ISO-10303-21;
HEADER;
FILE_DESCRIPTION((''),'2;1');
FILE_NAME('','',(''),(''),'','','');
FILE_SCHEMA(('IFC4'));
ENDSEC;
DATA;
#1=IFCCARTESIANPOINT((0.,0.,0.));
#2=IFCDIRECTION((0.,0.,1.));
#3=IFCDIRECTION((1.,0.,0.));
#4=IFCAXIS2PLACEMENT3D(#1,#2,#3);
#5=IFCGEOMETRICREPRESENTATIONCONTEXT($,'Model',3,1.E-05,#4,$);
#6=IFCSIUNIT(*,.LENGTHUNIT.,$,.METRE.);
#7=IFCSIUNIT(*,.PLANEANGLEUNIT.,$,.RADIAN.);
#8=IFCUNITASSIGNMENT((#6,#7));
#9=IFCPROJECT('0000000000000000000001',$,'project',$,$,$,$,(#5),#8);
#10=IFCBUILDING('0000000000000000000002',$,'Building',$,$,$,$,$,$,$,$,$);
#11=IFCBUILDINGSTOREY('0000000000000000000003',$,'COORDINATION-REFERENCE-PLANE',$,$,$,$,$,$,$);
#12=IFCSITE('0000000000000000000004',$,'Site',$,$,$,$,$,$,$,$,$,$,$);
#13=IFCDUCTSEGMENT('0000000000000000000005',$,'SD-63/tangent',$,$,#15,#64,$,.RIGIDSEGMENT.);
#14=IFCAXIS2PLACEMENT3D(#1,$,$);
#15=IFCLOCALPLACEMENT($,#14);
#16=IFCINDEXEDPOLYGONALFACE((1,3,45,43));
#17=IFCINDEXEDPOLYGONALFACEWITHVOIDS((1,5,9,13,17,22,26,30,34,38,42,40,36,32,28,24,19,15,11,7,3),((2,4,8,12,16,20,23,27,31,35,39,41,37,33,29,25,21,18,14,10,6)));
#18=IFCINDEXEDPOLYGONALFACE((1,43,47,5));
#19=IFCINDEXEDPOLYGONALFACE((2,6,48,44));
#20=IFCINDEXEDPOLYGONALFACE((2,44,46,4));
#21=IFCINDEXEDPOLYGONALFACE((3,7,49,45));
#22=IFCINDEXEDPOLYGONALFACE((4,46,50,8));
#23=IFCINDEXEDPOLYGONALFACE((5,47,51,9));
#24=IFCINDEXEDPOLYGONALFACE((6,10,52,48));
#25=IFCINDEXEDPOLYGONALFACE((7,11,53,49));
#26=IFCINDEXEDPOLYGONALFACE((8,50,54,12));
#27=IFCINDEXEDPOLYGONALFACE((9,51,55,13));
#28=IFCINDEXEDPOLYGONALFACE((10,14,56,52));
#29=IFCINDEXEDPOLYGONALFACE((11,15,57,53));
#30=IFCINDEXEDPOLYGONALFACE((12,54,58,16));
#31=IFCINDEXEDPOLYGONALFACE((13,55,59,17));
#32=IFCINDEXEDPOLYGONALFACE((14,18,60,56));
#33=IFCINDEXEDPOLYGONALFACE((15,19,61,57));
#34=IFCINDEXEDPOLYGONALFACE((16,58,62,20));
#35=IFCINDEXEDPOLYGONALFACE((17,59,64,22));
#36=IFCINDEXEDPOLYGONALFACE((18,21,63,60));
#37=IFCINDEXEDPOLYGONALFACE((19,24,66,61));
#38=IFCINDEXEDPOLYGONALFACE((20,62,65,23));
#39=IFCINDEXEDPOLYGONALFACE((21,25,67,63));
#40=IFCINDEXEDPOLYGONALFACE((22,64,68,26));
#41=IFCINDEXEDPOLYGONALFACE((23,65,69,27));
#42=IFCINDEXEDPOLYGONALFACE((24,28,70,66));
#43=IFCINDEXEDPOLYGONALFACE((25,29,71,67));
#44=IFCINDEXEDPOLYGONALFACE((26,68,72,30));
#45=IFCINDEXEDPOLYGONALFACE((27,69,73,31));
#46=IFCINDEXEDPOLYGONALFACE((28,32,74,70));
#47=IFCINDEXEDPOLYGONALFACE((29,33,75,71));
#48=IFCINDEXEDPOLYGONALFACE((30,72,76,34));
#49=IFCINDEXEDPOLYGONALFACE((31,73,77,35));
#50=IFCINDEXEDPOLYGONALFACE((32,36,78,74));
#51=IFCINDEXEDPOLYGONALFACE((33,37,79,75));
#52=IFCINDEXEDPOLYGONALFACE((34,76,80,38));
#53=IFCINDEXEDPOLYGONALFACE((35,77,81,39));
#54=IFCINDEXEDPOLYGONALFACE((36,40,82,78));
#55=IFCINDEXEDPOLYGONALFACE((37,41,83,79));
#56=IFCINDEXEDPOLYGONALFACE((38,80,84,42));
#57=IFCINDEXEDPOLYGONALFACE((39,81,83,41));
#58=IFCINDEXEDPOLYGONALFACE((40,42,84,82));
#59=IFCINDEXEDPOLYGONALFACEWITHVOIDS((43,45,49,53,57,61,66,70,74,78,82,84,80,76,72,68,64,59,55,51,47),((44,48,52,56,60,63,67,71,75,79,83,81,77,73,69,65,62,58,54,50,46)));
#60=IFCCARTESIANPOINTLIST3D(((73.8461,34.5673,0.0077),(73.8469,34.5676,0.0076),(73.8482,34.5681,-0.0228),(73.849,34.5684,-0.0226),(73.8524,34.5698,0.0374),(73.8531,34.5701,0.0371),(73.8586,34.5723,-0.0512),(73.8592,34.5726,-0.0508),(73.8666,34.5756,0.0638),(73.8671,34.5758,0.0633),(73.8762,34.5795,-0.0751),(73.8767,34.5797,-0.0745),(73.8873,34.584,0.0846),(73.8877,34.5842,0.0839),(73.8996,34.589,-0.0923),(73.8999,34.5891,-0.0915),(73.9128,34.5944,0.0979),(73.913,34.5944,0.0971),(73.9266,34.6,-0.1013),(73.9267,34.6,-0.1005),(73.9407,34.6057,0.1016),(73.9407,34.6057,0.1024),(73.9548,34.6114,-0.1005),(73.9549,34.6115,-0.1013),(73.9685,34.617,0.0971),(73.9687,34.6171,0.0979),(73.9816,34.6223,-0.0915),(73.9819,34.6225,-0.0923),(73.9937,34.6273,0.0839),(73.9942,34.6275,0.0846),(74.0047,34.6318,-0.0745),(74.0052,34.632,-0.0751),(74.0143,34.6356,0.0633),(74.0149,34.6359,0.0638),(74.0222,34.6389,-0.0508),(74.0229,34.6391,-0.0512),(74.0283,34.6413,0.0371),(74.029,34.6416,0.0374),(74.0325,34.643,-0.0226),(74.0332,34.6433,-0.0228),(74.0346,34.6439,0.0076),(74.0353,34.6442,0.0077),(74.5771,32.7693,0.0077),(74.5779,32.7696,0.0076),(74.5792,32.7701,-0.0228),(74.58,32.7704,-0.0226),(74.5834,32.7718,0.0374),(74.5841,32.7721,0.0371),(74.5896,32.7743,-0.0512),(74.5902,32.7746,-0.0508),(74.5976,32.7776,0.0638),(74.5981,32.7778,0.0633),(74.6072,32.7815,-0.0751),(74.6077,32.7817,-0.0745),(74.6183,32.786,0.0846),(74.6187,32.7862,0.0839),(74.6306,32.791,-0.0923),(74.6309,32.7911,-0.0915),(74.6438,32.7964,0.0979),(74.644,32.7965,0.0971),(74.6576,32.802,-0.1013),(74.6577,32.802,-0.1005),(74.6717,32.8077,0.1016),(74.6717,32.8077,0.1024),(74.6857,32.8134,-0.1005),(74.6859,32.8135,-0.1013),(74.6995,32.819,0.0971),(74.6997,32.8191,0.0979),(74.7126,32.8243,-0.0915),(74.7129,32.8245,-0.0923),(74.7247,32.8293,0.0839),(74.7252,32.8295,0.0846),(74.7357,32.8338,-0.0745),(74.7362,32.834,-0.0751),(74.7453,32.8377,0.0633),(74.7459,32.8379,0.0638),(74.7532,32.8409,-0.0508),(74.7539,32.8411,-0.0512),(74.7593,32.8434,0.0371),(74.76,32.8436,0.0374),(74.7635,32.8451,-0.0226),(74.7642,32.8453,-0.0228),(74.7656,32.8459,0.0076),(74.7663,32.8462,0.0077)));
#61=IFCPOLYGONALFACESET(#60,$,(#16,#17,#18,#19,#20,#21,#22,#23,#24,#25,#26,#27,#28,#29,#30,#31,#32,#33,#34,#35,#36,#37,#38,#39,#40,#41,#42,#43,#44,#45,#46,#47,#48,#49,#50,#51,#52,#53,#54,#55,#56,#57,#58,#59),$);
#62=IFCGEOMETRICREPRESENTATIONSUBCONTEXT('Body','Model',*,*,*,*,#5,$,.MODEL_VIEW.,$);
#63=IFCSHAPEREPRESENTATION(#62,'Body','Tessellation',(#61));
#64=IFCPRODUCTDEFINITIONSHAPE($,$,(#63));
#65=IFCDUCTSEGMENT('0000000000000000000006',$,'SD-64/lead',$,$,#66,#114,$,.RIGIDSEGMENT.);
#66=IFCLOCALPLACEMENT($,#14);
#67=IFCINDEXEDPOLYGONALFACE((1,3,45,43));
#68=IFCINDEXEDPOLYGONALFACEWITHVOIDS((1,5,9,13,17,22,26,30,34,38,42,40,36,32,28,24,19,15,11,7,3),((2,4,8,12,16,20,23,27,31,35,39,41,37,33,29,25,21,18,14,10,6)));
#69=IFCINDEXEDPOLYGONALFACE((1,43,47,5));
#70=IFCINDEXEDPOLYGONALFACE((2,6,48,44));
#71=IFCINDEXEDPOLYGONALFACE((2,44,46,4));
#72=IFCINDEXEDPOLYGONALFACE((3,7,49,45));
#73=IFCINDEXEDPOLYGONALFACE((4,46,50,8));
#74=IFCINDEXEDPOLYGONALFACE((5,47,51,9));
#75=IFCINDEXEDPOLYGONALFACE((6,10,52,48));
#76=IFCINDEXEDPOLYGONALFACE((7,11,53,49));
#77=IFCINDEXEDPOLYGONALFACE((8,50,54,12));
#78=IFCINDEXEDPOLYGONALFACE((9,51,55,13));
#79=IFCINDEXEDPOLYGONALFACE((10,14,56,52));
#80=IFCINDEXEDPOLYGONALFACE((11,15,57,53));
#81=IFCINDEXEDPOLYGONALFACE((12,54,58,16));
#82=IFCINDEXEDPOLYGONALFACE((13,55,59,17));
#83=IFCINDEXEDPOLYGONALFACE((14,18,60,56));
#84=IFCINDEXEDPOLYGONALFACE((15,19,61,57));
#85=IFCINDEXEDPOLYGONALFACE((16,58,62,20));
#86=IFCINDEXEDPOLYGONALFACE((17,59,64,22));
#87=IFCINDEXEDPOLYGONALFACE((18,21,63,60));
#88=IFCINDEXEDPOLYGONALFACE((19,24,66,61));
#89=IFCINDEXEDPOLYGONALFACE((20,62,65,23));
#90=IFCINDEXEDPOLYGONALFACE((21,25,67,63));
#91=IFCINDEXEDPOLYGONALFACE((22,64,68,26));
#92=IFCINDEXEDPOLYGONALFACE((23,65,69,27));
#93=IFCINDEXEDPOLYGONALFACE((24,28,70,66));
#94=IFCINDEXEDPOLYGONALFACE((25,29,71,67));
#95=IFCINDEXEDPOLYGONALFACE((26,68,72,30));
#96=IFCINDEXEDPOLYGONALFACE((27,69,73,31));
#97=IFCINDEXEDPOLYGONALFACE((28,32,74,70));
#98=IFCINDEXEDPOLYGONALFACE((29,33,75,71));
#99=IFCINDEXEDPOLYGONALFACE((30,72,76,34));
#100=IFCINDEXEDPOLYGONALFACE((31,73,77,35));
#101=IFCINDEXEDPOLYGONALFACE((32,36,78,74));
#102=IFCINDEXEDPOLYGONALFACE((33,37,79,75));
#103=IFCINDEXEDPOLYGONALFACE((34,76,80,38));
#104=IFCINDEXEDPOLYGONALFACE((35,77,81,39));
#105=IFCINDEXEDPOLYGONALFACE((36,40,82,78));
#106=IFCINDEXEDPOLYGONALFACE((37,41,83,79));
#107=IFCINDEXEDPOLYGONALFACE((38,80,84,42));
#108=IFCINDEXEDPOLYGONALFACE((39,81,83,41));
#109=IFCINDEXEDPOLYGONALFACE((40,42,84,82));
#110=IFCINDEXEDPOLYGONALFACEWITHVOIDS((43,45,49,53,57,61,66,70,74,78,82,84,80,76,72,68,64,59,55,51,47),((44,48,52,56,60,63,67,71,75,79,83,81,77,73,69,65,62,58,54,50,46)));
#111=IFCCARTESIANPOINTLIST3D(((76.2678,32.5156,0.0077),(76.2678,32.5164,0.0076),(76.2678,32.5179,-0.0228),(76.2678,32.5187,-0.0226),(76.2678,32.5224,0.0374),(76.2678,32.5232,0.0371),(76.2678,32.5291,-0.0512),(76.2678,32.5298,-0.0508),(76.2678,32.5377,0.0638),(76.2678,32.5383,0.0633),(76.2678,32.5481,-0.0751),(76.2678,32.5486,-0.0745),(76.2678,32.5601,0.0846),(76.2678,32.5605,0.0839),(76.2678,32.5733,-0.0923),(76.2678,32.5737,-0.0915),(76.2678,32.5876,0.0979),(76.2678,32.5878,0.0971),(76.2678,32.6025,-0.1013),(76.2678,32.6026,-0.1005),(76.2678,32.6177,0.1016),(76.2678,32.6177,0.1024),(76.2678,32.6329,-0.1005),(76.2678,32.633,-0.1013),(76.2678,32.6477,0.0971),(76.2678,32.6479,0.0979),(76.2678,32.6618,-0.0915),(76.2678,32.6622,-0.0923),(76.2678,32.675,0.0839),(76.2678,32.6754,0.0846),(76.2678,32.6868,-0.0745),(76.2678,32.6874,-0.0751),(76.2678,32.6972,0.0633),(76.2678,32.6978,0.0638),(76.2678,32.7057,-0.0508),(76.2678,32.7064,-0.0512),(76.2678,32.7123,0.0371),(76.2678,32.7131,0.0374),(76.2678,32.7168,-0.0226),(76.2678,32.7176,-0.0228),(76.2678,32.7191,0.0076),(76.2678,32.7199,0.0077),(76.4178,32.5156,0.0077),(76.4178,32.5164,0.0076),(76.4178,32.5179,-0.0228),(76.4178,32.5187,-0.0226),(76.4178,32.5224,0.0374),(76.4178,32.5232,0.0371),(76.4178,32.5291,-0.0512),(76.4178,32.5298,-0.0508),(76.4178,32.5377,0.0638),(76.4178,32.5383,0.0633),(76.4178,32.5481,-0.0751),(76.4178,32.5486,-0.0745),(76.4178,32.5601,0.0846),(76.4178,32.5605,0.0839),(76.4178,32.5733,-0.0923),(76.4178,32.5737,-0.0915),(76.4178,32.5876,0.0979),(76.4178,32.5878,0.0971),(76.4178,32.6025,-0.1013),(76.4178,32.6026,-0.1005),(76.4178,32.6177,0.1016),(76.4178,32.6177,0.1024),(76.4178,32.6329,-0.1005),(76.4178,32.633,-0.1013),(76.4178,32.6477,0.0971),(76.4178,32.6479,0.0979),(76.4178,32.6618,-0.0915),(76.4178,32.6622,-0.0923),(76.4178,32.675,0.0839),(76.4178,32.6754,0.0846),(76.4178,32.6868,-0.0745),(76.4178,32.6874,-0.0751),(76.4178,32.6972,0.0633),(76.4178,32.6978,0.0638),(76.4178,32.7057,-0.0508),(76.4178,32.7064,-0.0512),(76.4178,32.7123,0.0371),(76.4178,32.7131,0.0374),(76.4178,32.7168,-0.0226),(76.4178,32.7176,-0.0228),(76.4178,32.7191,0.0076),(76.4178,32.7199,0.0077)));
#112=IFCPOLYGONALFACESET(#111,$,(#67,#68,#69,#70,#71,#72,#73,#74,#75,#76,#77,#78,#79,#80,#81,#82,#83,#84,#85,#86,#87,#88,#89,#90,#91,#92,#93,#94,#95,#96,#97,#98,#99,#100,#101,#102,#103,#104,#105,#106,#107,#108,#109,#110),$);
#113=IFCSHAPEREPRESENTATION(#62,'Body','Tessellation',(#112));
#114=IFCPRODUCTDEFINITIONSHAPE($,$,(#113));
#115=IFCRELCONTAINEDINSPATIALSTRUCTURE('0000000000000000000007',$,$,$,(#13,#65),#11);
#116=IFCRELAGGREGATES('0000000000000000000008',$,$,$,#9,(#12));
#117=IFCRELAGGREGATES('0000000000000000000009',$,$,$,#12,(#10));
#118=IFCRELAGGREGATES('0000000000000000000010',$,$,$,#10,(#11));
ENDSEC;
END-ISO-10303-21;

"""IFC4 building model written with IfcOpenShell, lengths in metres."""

from ifc_helpers import new_model, si_unit, frame, origin_with_axes, place, context, subcontext, project, spatial, hollow_circle, extrude, element, save


model = new_model("IFC4")

# Units and contexts
model_context = context("Model", 3, precision=1e-05, world=origin_with_axes())
body_context_1 = subcontext(model_context, "Body", "Model", "MODEL_VIEW")
ifc_project = project(units=[si_unit("LENGTHUNIT", "METRE"), si_unit("PLANEANGLEUNIT", "RADIAN")], contexts=[model_context])

# Site, building, storey
site = spatial("IfcSite", under=ifc_project, Name="Site")
building = spatial("IfcBuilding", under=site, Name="Building")
storey = spatial("IfcBuildingStorey", under=building, Name="COORDINATION-REFERENCE-PLANE")

# Duct segment
duct_segment_1_placement = place(None, frame((74.6717, 32.8077, 0.0), z_axis=(-0.376625, 0.926366, 0.0), x_axis=(0.0, 0.0, 1.0)))
element("IfcDuctSegment", 1, at=duct_segment_1_placement, inside=storey, Name="SD-63/tangent", PredefinedType="RIGIDSEGMENT", context=body_context_1, shape_type="SweptSolid", body=[
    extrude(hollow_circle(Radius=0.1024, WallThickness=0.0008), origin_with_axes(), (0.0, 0.0, 1.0), 1.9409),
])

# Duct segment
duct_segment_2_placement = place(None, frame((76.2678, 32.6177, 0.0), z_axis=(1.0, 0.0, 0.0), x_axis=(0.0, 0.0, 1.0)))
element("IfcDuctSegment", 2, at=duct_segment_2_placement, inside=storey, Name="SD-64/lead", PredefinedType="RIGIDSEGMENT", context=body_context_1, shape_type="SweptSolid", body=[
    extrude(hollow_circle(Radius=0.1024, WallThickness=0.0008), origin_with_axes(), (0.0, 0.0, 1.0), 0.15),
])

save(model, "model.ifc")
